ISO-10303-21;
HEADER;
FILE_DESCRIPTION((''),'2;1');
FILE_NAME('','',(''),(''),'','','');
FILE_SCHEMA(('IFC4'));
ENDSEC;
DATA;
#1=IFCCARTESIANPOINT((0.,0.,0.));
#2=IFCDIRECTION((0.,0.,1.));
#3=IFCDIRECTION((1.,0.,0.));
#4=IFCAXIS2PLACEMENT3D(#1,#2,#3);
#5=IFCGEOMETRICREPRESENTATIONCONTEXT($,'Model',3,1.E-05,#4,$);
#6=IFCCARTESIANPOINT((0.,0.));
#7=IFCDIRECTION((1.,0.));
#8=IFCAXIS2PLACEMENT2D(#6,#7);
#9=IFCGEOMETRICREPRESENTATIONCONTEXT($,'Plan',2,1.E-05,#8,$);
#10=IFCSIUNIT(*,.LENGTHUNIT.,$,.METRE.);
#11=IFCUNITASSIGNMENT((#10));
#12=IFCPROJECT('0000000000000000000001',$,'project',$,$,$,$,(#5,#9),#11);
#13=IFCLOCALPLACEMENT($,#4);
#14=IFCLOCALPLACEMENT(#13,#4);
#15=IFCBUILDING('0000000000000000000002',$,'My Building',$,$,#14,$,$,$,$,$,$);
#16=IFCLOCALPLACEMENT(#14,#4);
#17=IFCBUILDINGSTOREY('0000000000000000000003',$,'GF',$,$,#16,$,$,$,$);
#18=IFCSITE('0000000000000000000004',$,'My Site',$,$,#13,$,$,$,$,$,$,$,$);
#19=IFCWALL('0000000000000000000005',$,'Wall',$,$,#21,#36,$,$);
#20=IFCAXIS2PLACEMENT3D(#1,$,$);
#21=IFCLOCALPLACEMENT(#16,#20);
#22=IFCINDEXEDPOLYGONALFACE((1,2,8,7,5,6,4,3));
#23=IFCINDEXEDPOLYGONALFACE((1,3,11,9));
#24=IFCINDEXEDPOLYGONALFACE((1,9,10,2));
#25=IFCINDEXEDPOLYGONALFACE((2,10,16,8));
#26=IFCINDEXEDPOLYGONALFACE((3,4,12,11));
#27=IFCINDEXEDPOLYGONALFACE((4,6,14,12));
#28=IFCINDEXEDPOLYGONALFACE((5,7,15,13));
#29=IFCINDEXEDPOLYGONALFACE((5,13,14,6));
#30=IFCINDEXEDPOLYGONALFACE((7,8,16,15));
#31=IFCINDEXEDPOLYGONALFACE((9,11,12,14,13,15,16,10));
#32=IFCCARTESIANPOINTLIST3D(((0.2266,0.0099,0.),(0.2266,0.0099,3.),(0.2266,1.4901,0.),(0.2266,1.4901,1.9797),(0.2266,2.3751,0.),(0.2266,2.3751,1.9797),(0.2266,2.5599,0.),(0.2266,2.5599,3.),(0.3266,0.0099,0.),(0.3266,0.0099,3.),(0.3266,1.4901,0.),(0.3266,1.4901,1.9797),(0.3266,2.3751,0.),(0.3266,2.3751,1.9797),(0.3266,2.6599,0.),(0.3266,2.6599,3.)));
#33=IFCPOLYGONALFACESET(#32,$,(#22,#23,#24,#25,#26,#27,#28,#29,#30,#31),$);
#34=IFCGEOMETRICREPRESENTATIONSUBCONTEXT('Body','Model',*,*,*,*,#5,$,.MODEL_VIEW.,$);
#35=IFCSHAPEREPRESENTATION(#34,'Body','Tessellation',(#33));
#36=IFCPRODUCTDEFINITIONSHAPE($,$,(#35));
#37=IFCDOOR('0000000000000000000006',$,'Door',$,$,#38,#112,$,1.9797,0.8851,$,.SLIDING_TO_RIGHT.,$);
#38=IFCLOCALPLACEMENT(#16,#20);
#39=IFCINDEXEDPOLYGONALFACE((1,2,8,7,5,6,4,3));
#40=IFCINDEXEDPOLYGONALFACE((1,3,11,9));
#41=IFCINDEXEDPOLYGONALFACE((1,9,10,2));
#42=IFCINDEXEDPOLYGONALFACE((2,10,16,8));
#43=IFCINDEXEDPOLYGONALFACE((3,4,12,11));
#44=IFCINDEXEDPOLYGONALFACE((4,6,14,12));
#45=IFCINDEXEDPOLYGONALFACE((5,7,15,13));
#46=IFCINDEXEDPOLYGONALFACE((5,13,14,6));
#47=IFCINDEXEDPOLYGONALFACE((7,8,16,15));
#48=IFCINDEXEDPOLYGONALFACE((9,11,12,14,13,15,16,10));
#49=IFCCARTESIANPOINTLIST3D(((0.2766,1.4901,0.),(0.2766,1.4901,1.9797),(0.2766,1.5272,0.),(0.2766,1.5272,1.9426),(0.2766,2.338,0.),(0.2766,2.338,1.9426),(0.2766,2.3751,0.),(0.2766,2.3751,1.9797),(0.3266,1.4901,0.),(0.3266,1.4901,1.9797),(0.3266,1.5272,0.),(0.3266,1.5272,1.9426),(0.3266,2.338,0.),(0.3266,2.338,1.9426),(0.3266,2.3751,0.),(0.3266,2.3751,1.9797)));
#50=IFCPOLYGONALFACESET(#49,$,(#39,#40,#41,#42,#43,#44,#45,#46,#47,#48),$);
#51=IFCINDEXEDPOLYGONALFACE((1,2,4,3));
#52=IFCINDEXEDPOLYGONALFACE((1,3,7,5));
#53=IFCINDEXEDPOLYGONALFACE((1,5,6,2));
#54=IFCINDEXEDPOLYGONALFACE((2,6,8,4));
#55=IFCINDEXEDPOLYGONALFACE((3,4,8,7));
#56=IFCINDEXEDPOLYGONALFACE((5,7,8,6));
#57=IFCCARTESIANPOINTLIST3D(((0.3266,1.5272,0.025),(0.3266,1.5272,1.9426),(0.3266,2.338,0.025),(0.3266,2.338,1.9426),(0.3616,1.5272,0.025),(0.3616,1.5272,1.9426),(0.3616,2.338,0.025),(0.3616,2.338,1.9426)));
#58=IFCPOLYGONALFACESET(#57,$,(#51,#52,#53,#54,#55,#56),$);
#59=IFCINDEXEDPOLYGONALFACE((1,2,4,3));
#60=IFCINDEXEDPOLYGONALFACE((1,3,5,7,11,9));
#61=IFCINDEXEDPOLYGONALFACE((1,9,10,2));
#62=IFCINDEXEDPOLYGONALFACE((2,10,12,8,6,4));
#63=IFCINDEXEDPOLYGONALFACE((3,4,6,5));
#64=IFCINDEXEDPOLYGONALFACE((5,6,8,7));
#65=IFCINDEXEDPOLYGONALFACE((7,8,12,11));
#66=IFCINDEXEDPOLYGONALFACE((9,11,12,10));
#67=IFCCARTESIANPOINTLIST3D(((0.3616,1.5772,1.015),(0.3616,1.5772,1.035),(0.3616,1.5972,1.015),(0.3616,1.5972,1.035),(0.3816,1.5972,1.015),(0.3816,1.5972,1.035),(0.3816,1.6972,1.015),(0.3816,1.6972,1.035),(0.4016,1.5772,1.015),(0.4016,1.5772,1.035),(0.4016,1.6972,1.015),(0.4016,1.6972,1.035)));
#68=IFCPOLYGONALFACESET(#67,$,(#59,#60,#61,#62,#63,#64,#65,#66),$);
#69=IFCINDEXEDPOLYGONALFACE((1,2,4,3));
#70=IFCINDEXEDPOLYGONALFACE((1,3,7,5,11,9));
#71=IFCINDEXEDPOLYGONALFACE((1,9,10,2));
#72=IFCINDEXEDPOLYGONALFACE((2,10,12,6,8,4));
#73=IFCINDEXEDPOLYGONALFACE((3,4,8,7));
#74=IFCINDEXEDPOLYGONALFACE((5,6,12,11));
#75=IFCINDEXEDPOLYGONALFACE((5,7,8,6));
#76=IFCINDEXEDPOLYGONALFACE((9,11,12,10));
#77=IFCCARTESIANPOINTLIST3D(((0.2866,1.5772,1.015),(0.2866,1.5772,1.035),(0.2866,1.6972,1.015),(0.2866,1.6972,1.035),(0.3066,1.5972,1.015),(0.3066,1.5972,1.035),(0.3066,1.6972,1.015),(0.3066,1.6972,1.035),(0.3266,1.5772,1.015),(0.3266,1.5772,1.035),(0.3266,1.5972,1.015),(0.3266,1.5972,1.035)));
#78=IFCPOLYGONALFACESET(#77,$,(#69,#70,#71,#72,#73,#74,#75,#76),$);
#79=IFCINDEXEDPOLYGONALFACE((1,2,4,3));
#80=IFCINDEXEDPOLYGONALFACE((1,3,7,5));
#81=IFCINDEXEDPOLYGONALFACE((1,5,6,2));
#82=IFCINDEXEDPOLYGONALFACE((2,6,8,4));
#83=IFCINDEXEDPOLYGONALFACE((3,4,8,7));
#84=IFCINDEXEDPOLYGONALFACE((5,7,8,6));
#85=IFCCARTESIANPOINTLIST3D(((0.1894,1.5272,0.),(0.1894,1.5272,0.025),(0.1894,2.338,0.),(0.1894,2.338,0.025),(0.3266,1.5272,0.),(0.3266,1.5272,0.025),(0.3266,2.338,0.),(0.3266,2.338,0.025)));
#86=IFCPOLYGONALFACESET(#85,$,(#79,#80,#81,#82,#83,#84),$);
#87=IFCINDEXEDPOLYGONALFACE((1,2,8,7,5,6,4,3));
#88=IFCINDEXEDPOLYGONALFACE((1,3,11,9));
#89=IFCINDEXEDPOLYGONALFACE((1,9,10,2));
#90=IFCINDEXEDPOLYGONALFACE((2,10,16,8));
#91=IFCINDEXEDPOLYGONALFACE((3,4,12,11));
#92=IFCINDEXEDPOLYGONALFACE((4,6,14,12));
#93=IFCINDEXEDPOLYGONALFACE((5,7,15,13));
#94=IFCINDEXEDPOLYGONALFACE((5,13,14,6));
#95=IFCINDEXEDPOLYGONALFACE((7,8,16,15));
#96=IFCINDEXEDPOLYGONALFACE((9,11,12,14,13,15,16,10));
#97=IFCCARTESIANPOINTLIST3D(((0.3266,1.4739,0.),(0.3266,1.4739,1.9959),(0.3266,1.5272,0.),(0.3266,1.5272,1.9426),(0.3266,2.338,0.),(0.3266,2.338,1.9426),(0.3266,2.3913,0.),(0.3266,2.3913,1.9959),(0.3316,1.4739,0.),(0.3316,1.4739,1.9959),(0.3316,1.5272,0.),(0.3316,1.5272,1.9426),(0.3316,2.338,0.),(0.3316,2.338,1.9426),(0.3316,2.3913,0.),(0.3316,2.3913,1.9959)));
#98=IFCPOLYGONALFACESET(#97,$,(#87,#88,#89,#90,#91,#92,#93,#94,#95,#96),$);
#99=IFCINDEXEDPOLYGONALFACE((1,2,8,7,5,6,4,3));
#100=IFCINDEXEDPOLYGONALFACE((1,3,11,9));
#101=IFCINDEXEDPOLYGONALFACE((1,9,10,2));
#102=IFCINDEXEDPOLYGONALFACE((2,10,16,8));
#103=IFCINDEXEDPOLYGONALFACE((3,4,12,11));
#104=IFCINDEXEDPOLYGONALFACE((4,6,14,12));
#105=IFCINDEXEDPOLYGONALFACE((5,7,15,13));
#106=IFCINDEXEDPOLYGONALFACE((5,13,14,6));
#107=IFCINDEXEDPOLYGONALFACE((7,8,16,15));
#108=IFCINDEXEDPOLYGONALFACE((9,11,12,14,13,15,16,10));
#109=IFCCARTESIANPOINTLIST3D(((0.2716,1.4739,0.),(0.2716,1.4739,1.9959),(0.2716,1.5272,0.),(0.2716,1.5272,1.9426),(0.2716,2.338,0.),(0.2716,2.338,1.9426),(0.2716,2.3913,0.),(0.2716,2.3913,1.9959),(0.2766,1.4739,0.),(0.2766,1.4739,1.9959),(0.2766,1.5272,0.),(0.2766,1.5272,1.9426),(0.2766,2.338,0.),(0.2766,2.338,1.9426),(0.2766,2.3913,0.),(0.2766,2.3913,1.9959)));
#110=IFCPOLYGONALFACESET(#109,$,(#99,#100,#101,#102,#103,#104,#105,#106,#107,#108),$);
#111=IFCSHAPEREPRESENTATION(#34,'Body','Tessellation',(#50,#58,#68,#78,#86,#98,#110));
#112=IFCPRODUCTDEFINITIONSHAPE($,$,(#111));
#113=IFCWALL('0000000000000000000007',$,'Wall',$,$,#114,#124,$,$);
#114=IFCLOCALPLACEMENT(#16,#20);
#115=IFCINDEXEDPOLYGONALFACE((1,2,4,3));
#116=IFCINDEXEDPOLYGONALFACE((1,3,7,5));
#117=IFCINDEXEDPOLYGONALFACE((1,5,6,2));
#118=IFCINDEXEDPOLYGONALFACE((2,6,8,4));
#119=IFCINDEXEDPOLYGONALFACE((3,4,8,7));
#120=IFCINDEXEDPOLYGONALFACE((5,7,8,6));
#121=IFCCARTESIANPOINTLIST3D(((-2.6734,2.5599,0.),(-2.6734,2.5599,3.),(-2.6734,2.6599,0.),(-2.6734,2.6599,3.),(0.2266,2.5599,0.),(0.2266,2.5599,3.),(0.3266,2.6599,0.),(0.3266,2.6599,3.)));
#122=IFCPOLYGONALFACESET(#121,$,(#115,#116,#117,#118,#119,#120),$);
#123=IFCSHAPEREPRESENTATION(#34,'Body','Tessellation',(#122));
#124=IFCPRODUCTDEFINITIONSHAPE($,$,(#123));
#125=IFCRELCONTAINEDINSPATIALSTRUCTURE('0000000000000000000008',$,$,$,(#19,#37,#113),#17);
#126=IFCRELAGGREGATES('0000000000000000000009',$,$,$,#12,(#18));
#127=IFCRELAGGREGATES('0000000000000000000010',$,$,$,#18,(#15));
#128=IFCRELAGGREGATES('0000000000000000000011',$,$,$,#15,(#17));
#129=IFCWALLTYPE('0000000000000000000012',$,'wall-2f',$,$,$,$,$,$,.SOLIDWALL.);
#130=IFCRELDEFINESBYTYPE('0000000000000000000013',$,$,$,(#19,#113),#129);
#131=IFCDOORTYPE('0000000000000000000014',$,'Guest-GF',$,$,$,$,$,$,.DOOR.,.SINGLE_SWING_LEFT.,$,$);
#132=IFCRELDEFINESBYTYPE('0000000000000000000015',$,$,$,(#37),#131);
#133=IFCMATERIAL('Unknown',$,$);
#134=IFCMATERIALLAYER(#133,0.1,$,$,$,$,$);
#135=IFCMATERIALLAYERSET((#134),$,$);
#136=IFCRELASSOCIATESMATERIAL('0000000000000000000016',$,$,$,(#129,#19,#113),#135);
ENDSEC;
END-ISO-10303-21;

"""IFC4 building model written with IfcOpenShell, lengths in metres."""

from ifc_helpers import new_model, entity, si_unit, frame, origin_with_axes, origin_2d_with_axis, place, context, subcontext, project, spatial, line, indexed_curve, outline, extrude, shape, source, transform, mapped, material, layer, layer_set, layer_usage, type_object, type_shapes, element, fill, save


model = new_model("IFC4")

# Units and contexts
model_context = context("Model", 3, precision=1e-05, world=origin_with_axes())
plan_context = context("Plan", 2, precision=1e-05, world=origin_2d_with_axis())
body_context_1 = subcontext(model_context, "Body", "Model", "MODEL_VIEW")
body_context_2 = subcontext(plan_context, "Body", "Plan", "PLAN_VIEW")
ifc_project = project(units=[si_unit("LENGTHUNIT", "METRE")], contexts=[model_context, plan_context])

# Site, building, storey
site_placement = place(None, origin_with_axes())
site = spatial("IfcSite", under=ifc_project, at=site_placement, Name="My Site")
building_placement = place(site_placement, origin_with_axes())
building = spatial("IfcBuilding", under=site, at=building_placement, Name="My Building")
storey_placement = place(building_placement, origin_with_axes())
storey = spatial("IfcBuildingStorey", under=building, at=storey_placement, Name="GF")

# Shared definitions
ifc_material = material(Name="Unknown")

# Shared definitions
ifc_layer_1 = layer(ifc_material, 0.1)
ifc_layer_set_1 = layer_set([ifc_layer_1])
wall_type = type_object("IfcWallType", Name="wall-2f", PredefinedType="SOLIDWALL", material=ifc_layer_set_1)

# Wall, opening, door
ifc_layer_usage_1 = layer_usage(ifc_layer_set_1, "AXIS2", "POSITIVE", 0.0)
wall_1_placement = place(storey_placement, frame((0.3266, 0.0099, 0.0), z_axis=(0.0, 0.0, 1.0), x_axis=(0.0, 1.0, 0.0)))
wall_1 = element("IfcWall", 1, at=wall_1_placement, inside=storey, type_object=wall_type, material=ifc_layer_usage_1, Name="Wall", context=body_context_1, shape_type="SweptSolid", body=[
    extrude(outline(indexed_curve([(0.0, 0.0), (0.0, 0.1), (2.55, 0.1), (2.65, 0.0)], segments=[line(1, 2, 3, 4, 1)])), origin_with_axes(), (0.0, 0.0, 1.0), 3.0),
])
shared_shape_1 = source(origin_with_axes(), body_context_1, "Body", "SweptSolid", [
    extrude(outline(indexed_curve([(0.0, 0.0), (0.8851, 0.0), (0.8851, 1.9797), (0.0, 1.9797)], segments=[line(1, 2, 3, 4, 1)])), frame((0.0, -0.6, 0.0), z_axis=(0.0, -1.0, 0.0), x_axis=(1.0, 0.0, 0.0)), (0.0, 0.0, -1.0), 1.2),
])
opening_1_placement = place(wall_1_placement, frame((1.4802, 0.0, 0.0), z_axis=(0.0, 0.0, 1.0), x_axis=(1.0, 0.0, 0.0)))
opening_1 = element("IfcOpeningElement", 2, at=opening_1_placement, cuts=wall_1, PredefinedType="OPENING", context=body_context_1, shape_type="MappedRepresentation", body=[
    mapped(shared_shape_1, transform((0.0, 0.0, 0.0), x_axis=(1.0, 0.0, 0.0), y_axis=(0.0, 1.0, 0.0), z_axis=(0.0, 0.0, 1.0), scale=1.0)),
])
door_type_1 = type_object("IfcDoorType", Name="Guest-GF", OperationType="SINGLE_SWING_LEFT", PredefinedType="DOOR")
shared_shape_2 = source(origin_with_axes(), body_context_1, "Body", "SweptSolid", [
    extrude(outline(indexed_curve([(0.0, 0.0), (0.0, 1.9797), (0.8851, 1.9797), (0.8851, 0.0), (0.848, 0.0), (0.848, 1.9426), (0.0371, 1.9426), (0.0371, 0.0)], segments=[line(1, 2, 3, 4, 5, 6, 7, 8, 1)])), frame((0.0, 0.0, 0.0), z_axis=(0.0, -1.0, 0.0), x_axis=(1.0, 0.0, 0.0)), (0.0, 0.0, -1.0), 0.05),
    extrude(outline(indexed_curve([(0.0, 0.0), (0.8109, 0.0), (0.8109, 0.035), (0.0, 0.035)], segments=[line(1, 2, 3, 4, 1)])), frame((0.0371, -0.035, 0.025), z_axis=(0.0, 0.0, 1.0), x_axis=(1.0, 0.0, 0.0)), (0.0, 0.0, 1.0), 1.9176),
    extrude(outline(indexed_curve([(0.0, 0.0), (0.0, -0.04), (0.12, -0.04), (0.12, -0.02), (0.02, -0.02), (0.02, 0.0)], segments=[line(1, 2, 3, 4, 5, 6, 1)])), frame((0.0871, -0.035, 1.015), z_axis=(0.0, 0.0, 1.0), x_axis=(1.0, 0.0, 0.0)), (0.0, 0.0, 1.0), 0.02),
    extrude(outline(indexed_curve([(0.0, 0.0), (0.0, 0.04), (0.12, 0.04), (0.12, 0.02), (0.02, 0.02), (0.02, 0.0)], segments=[line(1, 2, 3, 4, 5, 6, 1)])), frame((0.0871, 0.0, 1.015), z_axis=(0.0, 0.0, 1.0), x_axis=(1.0, 0.0, 0.0)), (0.0, 0.0, 1.0), 0.02),
    extrude(outline(indexed_curve([(0.0, 0.0), (0.8109, 0.0), (0.8109, 0.1372), (0.0, 0.1372)], segments=[line(1, 2, 3, 4, 1)])), frame((0.0371, 0.0, 0.0), z_axis=(0.0, 0.0, 1.0), x_axis=(1.0, 0.0, 0.0)), (0.0, 0.0, 1.0), 0.025),
    extrude(outline(indexed_curve([(0.0, 0.0), (0.0, 1.9959), (0.9174, 1.9959), (0.9174, 0.0), (0.8641, 0.0), (0.8641, 1.9426), (0.0532, 1.9426), (0.0532, 0.0)], segments=[line(1, 2, 3, 4, 5, 6, 7, 8, 1)])), frame((-0.0162, -0.005, 0.0), z_axis=(0.0, -1.0, 0.0), x_axis=(1.0, 0.0, 0.0)), (0.0, 0.0, -1.0), 0.005),
    extrude(outline(indexed_curve([(0.0, 0.0), (0.0, 1.9959), (0.9174, 1.9959), (0.9174, 0.0), (0.8641, 0.0), (0.8641, 1.9426), (0.0532, 1.9426), (0.0532, 0.0)], segments=[line(1, 2, 3, 4, 5, 6, 7, 8, 1)])), frame((-0.0162, 0.05, 0.0), z_axis=(0.0, -1.0, 0.0), x_axis=(1.0, 0.0, 0.0)), (0.0, 0.0, -1.0), 0.005),
])
shared_shape_3 = source(origin_with_axes(), body_context_2, "Body", "Curve2D", [
    entity("IfcIndexedPolyCurve", entity("IfcCartesianPointList2D", [[0.0, 0.0], [0.0371, 0.0], [0.0371, 0.05], [0.0, 0.05]]), [entity("IfcLineIndex", [1, 2, 3, 4, 1])]),
    entity("IfcIndexedPolyCurve", entity("IfcCartesianPointList2D", [[0.8851, 0.0], [0.848, 0.0], [0.848, 0.05], [0.8851, 0.05]]), [entity("IfcLineIndex", [1, 2, 3, 4, 1])]),
    entity("IfcIndexedPolyCurve", entity("IfcCartesianPointList2D", [[1.2534, -0.035], [0.4425, -0.035], [0.4425, 0.0], [1.2534, 0.0]]), [entity("IfcLineIndex", [1, 2, 3, 4, 1])]),
])
type_shapes(door_type_1, [shared_shape_2, shared_shape_3])
door_1_placement = place(opening_1_placement, frame((0.0, 0.0, 0.0), z_axis=(0.0, 0.0, 1.0), x_axis=(1.0, 0.0, 0.0)))
door_1 = element("IfcDoor", 3, at=door_1_placement, inside=storey, type_object=door_type_1, Name="Door", OperationType="SLIDING_TO_RIGHT", OverallHeight=1.9797, OverallWidth=0.8851, shapes=[
    shape(body_context_1, "Body", "MappedRepresentation", [mapped(shared_shape_2, transform((0.0, 0.0, 0.0), x_axis=(1.0, 0.0, 0.0), y_axis=(0.0, 1.0, 0.0), z_axis=(0.0, 0.0, 1.0), scale=1.0))]),
    shape(body_context_2, "Body", "MappedRepresentation", [mapped(shared_shape_3, transform((0.0, 0.0, 0.0), x_axis=(1.0, 0.0, 0.0), y_axis=(0.0, 1.0, 0.0), z_axis=(0.0, 0.0, 1.0), scale=1.0))]),
])
fill(opening_1, door_1)

# Wall
ifc_layer_usage_2 = layer_usage(ifc_layer_set_1, "AXIS2", "POSITIVE", 0.0)
wall_2_placement = place(storey_placement, frame((0.3266, 2.6599, 0.0), z_axis=(0.0, 0.0, 1.0), x_axis=(-1.0, 0.0, 0.0)))
element("IfcWall", 4, at=wall_2_placement, inside=storey, type_object=wall_type, material=ifc_layer_usage_2, Name="Wall", context=body_context_1, shape_type="SweptSolid", body=[
    extrude(outline(indexed_curve([(0.0, 0.0), (0.1, 0.1), (3.0, 0.1), (3.0, 0.0)], segments=[line(1, 2, 3, 4, 1)])), origin_with_axes(), (0.0, 0.0, 1.0), 3.0),
])

save(model, "model.ifc")
